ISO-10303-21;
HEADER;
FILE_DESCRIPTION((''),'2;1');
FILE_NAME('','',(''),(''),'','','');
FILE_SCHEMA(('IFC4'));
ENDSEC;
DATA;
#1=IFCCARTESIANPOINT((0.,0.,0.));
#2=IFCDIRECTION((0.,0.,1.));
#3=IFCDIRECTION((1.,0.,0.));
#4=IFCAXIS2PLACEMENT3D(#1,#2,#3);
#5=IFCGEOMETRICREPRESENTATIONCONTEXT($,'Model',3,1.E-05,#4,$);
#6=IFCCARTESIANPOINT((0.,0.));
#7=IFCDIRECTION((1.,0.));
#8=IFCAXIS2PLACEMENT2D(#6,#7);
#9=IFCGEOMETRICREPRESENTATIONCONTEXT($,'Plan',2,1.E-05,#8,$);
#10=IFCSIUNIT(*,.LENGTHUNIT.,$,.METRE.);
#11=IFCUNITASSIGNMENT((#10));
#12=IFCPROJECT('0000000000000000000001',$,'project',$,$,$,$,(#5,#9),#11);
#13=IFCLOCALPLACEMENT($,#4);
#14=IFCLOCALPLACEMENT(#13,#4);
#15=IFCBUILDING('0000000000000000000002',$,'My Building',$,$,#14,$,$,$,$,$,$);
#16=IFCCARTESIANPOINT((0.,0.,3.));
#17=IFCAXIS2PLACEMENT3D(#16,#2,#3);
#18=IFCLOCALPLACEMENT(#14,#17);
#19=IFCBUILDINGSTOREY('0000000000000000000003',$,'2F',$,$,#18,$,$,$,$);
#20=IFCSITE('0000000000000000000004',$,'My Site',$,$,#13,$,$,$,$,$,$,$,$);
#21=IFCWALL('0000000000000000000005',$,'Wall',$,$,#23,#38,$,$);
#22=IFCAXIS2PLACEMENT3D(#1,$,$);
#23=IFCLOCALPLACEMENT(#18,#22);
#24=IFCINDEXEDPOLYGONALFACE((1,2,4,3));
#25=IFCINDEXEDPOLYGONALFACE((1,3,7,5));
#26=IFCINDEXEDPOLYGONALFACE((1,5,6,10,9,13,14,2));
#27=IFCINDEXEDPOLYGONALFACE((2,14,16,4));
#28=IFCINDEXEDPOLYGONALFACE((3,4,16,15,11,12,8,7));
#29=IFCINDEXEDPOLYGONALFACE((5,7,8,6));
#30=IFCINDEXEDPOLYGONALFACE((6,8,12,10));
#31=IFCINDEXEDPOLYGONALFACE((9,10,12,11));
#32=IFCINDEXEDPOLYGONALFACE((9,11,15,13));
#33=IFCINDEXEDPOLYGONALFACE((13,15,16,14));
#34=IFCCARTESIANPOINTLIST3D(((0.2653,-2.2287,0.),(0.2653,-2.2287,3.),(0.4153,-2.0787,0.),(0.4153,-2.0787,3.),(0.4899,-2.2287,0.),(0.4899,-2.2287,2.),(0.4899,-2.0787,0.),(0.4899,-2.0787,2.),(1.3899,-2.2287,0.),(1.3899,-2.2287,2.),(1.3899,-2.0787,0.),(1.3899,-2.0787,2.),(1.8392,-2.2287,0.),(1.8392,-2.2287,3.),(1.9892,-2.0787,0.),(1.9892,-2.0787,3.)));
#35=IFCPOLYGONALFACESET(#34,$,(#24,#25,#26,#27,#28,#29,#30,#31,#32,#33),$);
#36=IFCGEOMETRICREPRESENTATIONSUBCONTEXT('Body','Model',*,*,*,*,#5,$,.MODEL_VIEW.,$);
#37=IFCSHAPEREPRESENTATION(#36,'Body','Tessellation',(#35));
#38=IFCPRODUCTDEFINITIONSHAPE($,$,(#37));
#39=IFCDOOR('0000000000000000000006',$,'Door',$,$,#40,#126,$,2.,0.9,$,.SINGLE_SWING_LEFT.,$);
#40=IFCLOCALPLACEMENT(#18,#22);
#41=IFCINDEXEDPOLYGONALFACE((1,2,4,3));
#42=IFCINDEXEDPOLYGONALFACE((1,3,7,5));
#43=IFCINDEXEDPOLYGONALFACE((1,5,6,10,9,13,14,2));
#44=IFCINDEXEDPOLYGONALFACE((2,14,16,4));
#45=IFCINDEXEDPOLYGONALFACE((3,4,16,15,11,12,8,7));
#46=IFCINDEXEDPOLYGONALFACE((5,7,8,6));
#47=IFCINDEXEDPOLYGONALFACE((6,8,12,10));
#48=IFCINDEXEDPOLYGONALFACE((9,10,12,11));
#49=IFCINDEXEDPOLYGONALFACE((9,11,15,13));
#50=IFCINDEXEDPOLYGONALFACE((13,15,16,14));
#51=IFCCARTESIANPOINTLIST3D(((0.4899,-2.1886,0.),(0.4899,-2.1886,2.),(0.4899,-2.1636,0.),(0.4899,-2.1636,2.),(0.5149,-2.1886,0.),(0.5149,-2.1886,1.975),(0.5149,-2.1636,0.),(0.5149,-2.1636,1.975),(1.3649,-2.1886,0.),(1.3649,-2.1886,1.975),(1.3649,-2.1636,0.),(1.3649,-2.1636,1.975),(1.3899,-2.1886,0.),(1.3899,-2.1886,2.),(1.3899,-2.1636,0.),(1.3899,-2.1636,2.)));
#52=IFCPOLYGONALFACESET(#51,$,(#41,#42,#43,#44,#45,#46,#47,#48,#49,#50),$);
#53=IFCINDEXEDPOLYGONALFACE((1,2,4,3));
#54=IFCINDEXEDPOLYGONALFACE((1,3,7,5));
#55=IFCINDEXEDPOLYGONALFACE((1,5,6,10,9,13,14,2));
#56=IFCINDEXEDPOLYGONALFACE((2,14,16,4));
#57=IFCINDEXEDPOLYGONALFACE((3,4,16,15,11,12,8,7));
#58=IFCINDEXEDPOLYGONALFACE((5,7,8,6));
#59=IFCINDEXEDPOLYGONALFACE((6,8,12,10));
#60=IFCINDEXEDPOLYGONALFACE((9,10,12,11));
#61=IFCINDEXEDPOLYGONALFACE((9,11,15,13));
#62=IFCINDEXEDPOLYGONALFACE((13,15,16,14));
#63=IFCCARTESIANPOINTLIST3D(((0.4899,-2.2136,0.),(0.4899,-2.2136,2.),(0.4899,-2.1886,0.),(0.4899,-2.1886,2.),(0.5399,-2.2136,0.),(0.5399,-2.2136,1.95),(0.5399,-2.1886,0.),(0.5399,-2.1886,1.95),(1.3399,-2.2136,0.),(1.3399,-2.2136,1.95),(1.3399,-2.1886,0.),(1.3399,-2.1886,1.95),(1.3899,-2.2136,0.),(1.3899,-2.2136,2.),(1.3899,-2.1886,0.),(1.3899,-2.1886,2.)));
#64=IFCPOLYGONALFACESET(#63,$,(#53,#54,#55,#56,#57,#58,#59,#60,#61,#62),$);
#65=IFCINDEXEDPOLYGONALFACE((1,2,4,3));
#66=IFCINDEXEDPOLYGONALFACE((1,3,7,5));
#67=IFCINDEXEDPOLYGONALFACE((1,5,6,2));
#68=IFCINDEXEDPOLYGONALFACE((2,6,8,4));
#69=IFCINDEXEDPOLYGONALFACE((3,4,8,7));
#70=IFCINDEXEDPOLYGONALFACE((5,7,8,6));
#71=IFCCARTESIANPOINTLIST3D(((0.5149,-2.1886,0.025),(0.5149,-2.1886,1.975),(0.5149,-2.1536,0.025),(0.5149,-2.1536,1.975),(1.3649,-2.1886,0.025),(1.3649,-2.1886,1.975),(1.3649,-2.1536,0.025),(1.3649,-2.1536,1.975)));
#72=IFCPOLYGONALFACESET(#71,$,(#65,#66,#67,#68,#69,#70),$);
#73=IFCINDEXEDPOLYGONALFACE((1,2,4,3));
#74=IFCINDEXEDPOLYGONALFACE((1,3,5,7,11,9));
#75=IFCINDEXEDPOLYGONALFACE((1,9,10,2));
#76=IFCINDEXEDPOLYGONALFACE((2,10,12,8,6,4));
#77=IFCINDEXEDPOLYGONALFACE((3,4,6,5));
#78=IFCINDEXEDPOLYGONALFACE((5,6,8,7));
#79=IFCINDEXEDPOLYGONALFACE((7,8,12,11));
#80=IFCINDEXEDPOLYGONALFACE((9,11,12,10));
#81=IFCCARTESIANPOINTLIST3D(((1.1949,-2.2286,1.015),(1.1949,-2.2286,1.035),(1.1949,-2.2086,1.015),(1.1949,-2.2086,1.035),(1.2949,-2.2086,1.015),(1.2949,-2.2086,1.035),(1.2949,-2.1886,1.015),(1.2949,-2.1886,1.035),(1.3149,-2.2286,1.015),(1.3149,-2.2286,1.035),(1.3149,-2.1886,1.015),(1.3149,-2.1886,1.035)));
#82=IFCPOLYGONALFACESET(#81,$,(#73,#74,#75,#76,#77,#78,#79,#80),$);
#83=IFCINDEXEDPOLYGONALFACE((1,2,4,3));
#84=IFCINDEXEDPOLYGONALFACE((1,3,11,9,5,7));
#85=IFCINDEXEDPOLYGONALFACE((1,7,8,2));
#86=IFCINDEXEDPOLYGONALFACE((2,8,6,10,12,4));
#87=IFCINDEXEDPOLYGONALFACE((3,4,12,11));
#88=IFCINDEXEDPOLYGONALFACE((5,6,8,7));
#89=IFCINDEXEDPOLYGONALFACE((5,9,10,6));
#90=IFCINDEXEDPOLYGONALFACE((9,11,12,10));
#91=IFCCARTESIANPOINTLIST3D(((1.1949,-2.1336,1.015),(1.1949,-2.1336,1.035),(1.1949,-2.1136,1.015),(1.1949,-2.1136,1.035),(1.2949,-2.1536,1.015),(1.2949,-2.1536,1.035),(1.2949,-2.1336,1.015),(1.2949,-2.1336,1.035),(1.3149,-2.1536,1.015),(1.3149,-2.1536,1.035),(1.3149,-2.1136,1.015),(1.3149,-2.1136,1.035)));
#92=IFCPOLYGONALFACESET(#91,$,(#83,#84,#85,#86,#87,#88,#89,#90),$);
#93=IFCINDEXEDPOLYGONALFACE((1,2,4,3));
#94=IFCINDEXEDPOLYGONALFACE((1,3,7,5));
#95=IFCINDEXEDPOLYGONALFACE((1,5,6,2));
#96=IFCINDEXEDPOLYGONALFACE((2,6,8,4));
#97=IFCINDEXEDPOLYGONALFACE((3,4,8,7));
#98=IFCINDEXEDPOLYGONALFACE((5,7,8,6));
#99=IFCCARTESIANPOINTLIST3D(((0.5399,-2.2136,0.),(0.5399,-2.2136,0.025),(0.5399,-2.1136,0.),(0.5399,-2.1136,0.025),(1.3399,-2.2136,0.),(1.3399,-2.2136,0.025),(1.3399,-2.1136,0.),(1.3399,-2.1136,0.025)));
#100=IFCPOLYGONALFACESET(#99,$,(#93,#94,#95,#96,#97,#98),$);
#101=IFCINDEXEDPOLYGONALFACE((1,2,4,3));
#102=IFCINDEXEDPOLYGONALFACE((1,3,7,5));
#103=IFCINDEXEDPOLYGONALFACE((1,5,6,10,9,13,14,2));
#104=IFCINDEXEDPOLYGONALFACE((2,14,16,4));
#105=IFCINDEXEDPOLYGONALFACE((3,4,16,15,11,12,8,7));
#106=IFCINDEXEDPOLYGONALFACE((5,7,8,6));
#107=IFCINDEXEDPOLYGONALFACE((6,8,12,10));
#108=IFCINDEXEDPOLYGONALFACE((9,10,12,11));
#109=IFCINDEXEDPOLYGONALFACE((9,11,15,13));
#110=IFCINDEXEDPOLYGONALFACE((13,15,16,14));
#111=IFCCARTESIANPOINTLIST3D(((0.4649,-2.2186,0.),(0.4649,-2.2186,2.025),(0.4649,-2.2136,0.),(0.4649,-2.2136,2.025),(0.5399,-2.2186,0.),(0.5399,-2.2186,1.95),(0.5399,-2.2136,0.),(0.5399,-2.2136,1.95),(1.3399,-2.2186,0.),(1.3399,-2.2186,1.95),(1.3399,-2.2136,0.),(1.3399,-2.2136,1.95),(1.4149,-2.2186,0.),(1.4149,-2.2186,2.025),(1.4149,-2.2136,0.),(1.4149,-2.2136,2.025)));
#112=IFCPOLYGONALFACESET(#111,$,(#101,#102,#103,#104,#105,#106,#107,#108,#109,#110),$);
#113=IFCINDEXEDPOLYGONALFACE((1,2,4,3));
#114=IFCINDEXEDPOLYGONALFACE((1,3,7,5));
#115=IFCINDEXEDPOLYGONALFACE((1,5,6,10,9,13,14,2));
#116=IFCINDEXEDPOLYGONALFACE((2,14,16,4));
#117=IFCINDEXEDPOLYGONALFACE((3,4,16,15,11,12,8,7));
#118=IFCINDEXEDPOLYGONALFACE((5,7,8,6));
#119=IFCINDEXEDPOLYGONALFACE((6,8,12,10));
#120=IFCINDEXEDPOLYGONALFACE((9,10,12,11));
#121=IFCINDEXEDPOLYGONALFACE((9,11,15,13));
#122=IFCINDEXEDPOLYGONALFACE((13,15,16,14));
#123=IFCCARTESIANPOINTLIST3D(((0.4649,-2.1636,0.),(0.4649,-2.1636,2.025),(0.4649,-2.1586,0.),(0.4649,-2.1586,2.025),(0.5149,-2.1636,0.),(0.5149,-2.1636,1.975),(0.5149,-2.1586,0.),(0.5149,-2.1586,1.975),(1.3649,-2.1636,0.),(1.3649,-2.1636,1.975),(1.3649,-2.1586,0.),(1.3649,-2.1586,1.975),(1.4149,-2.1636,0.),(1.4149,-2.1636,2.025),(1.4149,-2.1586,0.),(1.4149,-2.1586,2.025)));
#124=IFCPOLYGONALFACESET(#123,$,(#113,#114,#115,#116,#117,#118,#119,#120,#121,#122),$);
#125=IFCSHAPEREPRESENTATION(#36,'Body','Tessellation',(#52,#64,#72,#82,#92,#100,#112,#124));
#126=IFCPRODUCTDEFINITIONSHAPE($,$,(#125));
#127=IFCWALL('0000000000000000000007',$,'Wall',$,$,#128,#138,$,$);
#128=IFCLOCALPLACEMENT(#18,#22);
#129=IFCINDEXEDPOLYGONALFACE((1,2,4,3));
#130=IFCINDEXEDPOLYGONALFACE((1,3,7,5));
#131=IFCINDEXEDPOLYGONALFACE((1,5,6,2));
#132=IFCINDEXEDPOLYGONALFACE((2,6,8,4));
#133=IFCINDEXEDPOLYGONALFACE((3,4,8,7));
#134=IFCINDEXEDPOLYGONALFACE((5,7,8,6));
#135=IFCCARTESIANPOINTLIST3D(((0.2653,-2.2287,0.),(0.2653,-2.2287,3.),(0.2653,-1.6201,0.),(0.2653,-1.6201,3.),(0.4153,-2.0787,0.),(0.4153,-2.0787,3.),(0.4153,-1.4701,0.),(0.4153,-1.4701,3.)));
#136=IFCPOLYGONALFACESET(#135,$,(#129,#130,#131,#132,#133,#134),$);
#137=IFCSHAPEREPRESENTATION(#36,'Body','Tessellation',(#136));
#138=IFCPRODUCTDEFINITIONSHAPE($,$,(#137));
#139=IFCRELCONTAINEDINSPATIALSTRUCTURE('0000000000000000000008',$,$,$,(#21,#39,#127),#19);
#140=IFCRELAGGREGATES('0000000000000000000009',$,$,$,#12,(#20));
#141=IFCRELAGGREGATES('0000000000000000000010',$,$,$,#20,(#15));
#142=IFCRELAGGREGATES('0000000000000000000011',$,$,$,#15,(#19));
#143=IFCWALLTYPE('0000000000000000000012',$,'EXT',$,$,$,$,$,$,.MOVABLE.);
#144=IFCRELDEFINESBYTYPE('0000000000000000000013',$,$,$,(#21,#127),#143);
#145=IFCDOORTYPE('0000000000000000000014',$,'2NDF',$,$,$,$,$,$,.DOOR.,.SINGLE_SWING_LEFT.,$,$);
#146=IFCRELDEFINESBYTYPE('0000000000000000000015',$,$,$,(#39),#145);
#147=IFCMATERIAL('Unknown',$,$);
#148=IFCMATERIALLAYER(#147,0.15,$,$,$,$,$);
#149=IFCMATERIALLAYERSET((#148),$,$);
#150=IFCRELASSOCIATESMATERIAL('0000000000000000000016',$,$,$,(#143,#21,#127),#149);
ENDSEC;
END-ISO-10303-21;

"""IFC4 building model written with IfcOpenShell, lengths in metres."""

from ifc_helpers import new_model, entity, si_unit, frame, origin_with_axes, origin_2d_with_axis, place, context, subcontext, project, spatial, line, indexed_curve, outline, extrude, shape, source, transform, mapped, material, layer, layer_set, layer_usage, type_object, type_shapes, element, fill, save


model = new_model("IFC4")

# Units and contexts
model_context = context("Model", 3, precision=1e-05, world=origin_with_axes())
plan_context = context("Plan", 2, precision=1e-05, world=origin_2d_with_axis())
body_context_1 = subcontext(model_context, "Body", "Model", "MODEL_VIEW")
body_context_2 = subcontext(plan_context, "Body", "Plan", "PLAN_VIEW")
ifc_project = project(units=[si_unit("LENGTHUNIT", "METRE")], contexts=[model_context, plan_context])

# Site, building, storey
site_placement = place(None, origin_with_axes())
site = spatial("IfcSite", under=ifc_project, at=site_placement, Name="My Site")
building_placement = place(site_placement, origin_with_axes())
building = spatial("IfcBuilding", under=site, at=building_placement, Name="My Building")
storey_placement = place(building_placement, frame((0.0, 0.0, 3.0), z_axis=(0.0, 0.0, 1.0), x_axis=(1.0, 0.0, 0.0)))
storey = spatial("IfcBuildingStorey", under=building, at=storey_placement, Name="2F")

# Shared definitions
ifc_material = material(Name="Unknown")

# Shared definitions
ifc_layer_1 = layer(ifc_material, 0.15)
ifc_layer_set_1 = layer_set([ifc_layer_1])
wall_type_1 = type_object("IfcWallType", Name="EXT", PredefinedType="MOVABLE", material=ifc_layer_set_1)

# Wall, opening, door
ifc_layer_usage_1 = layer_usage(ifc_layer_set_1, "AXIS2", "POSITIVE", -0.15)
wall_1_placement = place(storey_placement, frame((1.8392, -2.2287, 0.0), z_axis=(0.0, 0.0, 1.0), x_axis=(-1.0, 0.0, 0.0)))
wall_1 = element("IfcWall", 1, at=wall_1_placement, inside=storey, type_object=wall_type_1, material=ifc_layer_usage_1, Name="Wall", context=body_context_1, shape_type="SweptSolid", body=[
    extrude(outline(indexed_curve([(-0.15, -0.15), (0.0, 0.0), (1.5739, 0.0), (1.4239, -0.15)], segments=[line(1, 2, 3, 4, 1)])), origin_with_axes(), (0.0, 0.0, 1.0), 3.0),
])
placement_1 = place(storey_placement, frame((0.4899, -2.2136, 0.0), z_axis=(0.0, 0.0, 1.0), x_axis=(1.0, 0.0, 0.0)))
opening_1 = element("IfcOpeningElement", 2, at=placement_1, cuts=wall_1, PredefinedType="OPENING", context=body_context_1, shape_type="SweptSolid", body=[
    extrude(outline(indexed_curve([(0.0, 0.0), (0.9, 0.0), (0.9, 2.0), (0.0, 2.0)], segments=[line(1, 2, 3, 4, 1)])), frame((0.0, -0.6, 0.0), z_axis=(0.0, -1.0, 0.0), x_axis=(1.0, 0.0, 0.0)), (0.0, 0.0, -1.0), 1.2),
])
door_type_1 = type_object("IfcDoorType", Name="2NDF", OperationType="SINGLE_SWING_LEFT", PredefinedType="DOOR")
shared_shape_1 = source(origin_with_axes(), body_context_1, "Body", "SweptSolid", [
    extrude(outline(indexed_curve([(0.0, 0.0), (0.0, 2.0), (0.9, 2.0), (0.9, 0.0), (0.875, 0.0), (0.875, 1.975), (0.025, 1.975), (0.025, 0.0)], segments=[line(1, 2, 3, 4, 5, 6, 7, 8, 1)])), frame((0.0, 0.025, 0.0), z_axis=(0.0, -1.0, 0.0), x_axis=(1.0, 0.0, 0.0)), (0.0, 0.0, -1.0), 0.025),
    extrude(outline(indexed_curve([(0.0, 0.0), (0.0, 2.0), (0.9, 2.0), (0.9, 0.0), (0.85, 0.0), (0.85, 1.95), (0.05, 1.95), (0.05, 0.0)], segments=[line(1, 2, 3, 4, 5, 6, 7, 8, 1)])), frame((0.0, 0.0, 0.0), z_axis=(0.0, -1.0, 0.0), x_axis=(1.0, 0.0, 0.0)), (0.0, 0.0, -1.0), 0.025),
    extrude(outline(indexed_curve([(0.0, 0.0), (0.85, 0.0), (0.85, 0.035), (0.0, 0.035)], segments=[line(1, 2, 3, 4, 1)])), frame((0.025, 0.025, 0.025), z_axis=(0.0, 0.0, 1.0), x_axis=(1.0, 0.0, 0.0)), (0.0, 0.0, 1.0), 1.95),
    extrude(outline(indexed_curve([(0.0, 0.0), (0.0, -0.04), (-0.12, -0.04), (-0.12, -0.02), (-0.02, -0.02), (-0.02, 0.0)], segments=[line(1, 2, 3, 4, 5, 6, 1)])), frame((0.825, 0.025, 1.015), z_axis=(0.0, 0.0, 1.0), x_axis=(1.0, 0.0, 0.0)), (0.0, 0.0, 1.0), 0.02),
    extrude(outline(indexed_curve([(0.0, 0.0), (0.0, 0.04), (-0.12, 0.04), (-0.12, 0.02), (-0.02, 0.02), (-0.02, 0.0)], segments=[line(1, 2, 3, 4, 5, 6, 1)])), frame((0.825, 0.06, 1.015), z_axis=(0.0, 0.0, 1.0), x_axis=(1.0, 0.0, 0.0)), (0.0, 0.0, 1.0), 0.02),
    extrude(outline(indexed_curve([(0.0, 0.0), (0.8, 0.0), (0.8, 0.1), (0.0, 0.1)], segments=[line(1, 2, 3, 4, 1)])), frame((0.05, 0.0, 0.0), z_axis=(0.0, 0.0, 1.0), x_axis=(1.0, 0.0, 0.0)), (0.0, 0.0, 1.0), 0.025),
    extrude(outline(indexed_curve([(0.0, 0.0), (0.0, 2.025), (0.95, 2.025), (0.95, 0.0), (0.875, 0.0), (0.875, 1.95), (0.075, 1.95), (0.075, 0.0)], segments=[line(1, 2, 3, 4, 5, 6, 7, 8, 1)])), frame((-0.025, -0.005, 0.0), z_axis=(0.0, -1.0, 0.0), x_axis=(1.0, 0.0, 0.0)), (0.0, 0.0, -1.0), 0.005),
    extrude(outline(indexed_curve([(0.0, 0.0), (0.0, 2.025), (0.95, 2.025), (0.95, 0.0), (0.9, 0.0), (0.9, 1.975), (0.05, 1.975), (0.05, 0.0)], segments=[line(1, 2, 3, 4, 5, 6, 7, 8, 1)])), frame((-0.025, 0.05, 0.0), z_axis=(0.0, -1.0, 0.0), x_axis=(1.0, 0.0, 0.0)), (0.0, 0.0, -1.0), 0.005),
])
shared_shape_2 = source(origin_with_axes(), body_context_2, "Body", "Curve2D", [
    entity("IfcIndexedPolyCurve", entity("IfcCartesianPointList2D", [[0.0, 0.0], [0.0, 0.05], [0.025, 0.05], [0.025, 0.025], [0.05, 0.025], [0.05, 0.0]]), [entity("IfcLineIndex", [1, 2, 3, 4, 5, 6, 1])]),
    entity("IfcIndexedPolyCurve", entity("IfcCartesianPointList2D", [[0.9, 0.0], [0.9, 0.05], [0.875, 0.05], [0.875, 0.025], [0.85, 0.025], [0.85, 0.0]]), [entity("IfcLineIndex", [1, 2, 3, 4, 5, 6, 1])]),
    entity("IfcTrimmedCurve", entity("IfcEllipse", entity("IfcAxis2Placement2D", entity("IfcCartesianPoint", [0.06, 0.05]), entity("IfcDirection", [1.0, 0.0])), 0.815, 0.85), [entity("IfcCartesianPoint", [0.875, 0.05])], [entity("IfcCartesianPoint", [0.06, 0.9])], True, "CARTESIAN"),
    entity("IfcIndexedPolyCurve", entity("IfcCartesianPointList2D", [[0.025, 0.05], [0.06, 0.05], [0.06, 0.9], [0.025, 0.9]]), [entity("IfcLineIndex", [1, 2, 3, 4, 1])]),
])
type_shapes(door_type_1, [shared_shape_1, shared_shape_2])
door_1 = element("IfcDoor", 3, at=placement_1, inside=storey, type_object=door_type_1, Name="Door", OperationType="SINGLE_SWING_LEFT", OverallHeight=2.0, OverallWidth=0.9, shapes=[
    shape(body_context_1, "Body", "MappedRepresentation", [mapped(shared_shape_1, transform((0.0, 0.0, 0.0), x_axis=(1.0, 0.0, 0.0), y_axis=(0.0, 1.0, 0.0), z_axis=(0.0, 0.0, 1.0), scale=1.0))]),
    shape(body_context_2, "Body", "MappedRepresentation", [mapped(shared_shape_2, transform((0.0, 0.0, 0.0), x_axis=(1.0, 0.0, 0.0), y_axis=(0.0, 1.0, 0.0), z_axis=(0.0, 0.0, 1.0), scale=1.0))]),
])
fill(opening_1, door_1)

# Wall
ifc_layer_usage_2 = layer_usage(ifc_layer_set_1, "AXIS2", "POSITIVE", -0.15)
wall_2_placement = place(storey_placement, frame((0.2653, -2.2287, 0.0), z_axis=(0.0, 0.0, 1.0), x_axis=(0.0, 1.0, 0.0)))
element("IfcWall", 4, at=wall_2_placement, inside=storey, type_object=wall_type_1, material=ifc_layer_usage_2, Name="Wall", context=body_context_1, shape_type="SweptSolid", body=[
    extrude(outline(indexed_curve([(0.15, -0.15), (0.0, 0.0), (0.6086, 0.0), (0.7586, -0.15)], segments=[line(1, 2, 3, 4, 1)])), origin_with_axes(), (0.0, 0.0, 1.0), 3.0),
])

save(model, "model.ifc")
